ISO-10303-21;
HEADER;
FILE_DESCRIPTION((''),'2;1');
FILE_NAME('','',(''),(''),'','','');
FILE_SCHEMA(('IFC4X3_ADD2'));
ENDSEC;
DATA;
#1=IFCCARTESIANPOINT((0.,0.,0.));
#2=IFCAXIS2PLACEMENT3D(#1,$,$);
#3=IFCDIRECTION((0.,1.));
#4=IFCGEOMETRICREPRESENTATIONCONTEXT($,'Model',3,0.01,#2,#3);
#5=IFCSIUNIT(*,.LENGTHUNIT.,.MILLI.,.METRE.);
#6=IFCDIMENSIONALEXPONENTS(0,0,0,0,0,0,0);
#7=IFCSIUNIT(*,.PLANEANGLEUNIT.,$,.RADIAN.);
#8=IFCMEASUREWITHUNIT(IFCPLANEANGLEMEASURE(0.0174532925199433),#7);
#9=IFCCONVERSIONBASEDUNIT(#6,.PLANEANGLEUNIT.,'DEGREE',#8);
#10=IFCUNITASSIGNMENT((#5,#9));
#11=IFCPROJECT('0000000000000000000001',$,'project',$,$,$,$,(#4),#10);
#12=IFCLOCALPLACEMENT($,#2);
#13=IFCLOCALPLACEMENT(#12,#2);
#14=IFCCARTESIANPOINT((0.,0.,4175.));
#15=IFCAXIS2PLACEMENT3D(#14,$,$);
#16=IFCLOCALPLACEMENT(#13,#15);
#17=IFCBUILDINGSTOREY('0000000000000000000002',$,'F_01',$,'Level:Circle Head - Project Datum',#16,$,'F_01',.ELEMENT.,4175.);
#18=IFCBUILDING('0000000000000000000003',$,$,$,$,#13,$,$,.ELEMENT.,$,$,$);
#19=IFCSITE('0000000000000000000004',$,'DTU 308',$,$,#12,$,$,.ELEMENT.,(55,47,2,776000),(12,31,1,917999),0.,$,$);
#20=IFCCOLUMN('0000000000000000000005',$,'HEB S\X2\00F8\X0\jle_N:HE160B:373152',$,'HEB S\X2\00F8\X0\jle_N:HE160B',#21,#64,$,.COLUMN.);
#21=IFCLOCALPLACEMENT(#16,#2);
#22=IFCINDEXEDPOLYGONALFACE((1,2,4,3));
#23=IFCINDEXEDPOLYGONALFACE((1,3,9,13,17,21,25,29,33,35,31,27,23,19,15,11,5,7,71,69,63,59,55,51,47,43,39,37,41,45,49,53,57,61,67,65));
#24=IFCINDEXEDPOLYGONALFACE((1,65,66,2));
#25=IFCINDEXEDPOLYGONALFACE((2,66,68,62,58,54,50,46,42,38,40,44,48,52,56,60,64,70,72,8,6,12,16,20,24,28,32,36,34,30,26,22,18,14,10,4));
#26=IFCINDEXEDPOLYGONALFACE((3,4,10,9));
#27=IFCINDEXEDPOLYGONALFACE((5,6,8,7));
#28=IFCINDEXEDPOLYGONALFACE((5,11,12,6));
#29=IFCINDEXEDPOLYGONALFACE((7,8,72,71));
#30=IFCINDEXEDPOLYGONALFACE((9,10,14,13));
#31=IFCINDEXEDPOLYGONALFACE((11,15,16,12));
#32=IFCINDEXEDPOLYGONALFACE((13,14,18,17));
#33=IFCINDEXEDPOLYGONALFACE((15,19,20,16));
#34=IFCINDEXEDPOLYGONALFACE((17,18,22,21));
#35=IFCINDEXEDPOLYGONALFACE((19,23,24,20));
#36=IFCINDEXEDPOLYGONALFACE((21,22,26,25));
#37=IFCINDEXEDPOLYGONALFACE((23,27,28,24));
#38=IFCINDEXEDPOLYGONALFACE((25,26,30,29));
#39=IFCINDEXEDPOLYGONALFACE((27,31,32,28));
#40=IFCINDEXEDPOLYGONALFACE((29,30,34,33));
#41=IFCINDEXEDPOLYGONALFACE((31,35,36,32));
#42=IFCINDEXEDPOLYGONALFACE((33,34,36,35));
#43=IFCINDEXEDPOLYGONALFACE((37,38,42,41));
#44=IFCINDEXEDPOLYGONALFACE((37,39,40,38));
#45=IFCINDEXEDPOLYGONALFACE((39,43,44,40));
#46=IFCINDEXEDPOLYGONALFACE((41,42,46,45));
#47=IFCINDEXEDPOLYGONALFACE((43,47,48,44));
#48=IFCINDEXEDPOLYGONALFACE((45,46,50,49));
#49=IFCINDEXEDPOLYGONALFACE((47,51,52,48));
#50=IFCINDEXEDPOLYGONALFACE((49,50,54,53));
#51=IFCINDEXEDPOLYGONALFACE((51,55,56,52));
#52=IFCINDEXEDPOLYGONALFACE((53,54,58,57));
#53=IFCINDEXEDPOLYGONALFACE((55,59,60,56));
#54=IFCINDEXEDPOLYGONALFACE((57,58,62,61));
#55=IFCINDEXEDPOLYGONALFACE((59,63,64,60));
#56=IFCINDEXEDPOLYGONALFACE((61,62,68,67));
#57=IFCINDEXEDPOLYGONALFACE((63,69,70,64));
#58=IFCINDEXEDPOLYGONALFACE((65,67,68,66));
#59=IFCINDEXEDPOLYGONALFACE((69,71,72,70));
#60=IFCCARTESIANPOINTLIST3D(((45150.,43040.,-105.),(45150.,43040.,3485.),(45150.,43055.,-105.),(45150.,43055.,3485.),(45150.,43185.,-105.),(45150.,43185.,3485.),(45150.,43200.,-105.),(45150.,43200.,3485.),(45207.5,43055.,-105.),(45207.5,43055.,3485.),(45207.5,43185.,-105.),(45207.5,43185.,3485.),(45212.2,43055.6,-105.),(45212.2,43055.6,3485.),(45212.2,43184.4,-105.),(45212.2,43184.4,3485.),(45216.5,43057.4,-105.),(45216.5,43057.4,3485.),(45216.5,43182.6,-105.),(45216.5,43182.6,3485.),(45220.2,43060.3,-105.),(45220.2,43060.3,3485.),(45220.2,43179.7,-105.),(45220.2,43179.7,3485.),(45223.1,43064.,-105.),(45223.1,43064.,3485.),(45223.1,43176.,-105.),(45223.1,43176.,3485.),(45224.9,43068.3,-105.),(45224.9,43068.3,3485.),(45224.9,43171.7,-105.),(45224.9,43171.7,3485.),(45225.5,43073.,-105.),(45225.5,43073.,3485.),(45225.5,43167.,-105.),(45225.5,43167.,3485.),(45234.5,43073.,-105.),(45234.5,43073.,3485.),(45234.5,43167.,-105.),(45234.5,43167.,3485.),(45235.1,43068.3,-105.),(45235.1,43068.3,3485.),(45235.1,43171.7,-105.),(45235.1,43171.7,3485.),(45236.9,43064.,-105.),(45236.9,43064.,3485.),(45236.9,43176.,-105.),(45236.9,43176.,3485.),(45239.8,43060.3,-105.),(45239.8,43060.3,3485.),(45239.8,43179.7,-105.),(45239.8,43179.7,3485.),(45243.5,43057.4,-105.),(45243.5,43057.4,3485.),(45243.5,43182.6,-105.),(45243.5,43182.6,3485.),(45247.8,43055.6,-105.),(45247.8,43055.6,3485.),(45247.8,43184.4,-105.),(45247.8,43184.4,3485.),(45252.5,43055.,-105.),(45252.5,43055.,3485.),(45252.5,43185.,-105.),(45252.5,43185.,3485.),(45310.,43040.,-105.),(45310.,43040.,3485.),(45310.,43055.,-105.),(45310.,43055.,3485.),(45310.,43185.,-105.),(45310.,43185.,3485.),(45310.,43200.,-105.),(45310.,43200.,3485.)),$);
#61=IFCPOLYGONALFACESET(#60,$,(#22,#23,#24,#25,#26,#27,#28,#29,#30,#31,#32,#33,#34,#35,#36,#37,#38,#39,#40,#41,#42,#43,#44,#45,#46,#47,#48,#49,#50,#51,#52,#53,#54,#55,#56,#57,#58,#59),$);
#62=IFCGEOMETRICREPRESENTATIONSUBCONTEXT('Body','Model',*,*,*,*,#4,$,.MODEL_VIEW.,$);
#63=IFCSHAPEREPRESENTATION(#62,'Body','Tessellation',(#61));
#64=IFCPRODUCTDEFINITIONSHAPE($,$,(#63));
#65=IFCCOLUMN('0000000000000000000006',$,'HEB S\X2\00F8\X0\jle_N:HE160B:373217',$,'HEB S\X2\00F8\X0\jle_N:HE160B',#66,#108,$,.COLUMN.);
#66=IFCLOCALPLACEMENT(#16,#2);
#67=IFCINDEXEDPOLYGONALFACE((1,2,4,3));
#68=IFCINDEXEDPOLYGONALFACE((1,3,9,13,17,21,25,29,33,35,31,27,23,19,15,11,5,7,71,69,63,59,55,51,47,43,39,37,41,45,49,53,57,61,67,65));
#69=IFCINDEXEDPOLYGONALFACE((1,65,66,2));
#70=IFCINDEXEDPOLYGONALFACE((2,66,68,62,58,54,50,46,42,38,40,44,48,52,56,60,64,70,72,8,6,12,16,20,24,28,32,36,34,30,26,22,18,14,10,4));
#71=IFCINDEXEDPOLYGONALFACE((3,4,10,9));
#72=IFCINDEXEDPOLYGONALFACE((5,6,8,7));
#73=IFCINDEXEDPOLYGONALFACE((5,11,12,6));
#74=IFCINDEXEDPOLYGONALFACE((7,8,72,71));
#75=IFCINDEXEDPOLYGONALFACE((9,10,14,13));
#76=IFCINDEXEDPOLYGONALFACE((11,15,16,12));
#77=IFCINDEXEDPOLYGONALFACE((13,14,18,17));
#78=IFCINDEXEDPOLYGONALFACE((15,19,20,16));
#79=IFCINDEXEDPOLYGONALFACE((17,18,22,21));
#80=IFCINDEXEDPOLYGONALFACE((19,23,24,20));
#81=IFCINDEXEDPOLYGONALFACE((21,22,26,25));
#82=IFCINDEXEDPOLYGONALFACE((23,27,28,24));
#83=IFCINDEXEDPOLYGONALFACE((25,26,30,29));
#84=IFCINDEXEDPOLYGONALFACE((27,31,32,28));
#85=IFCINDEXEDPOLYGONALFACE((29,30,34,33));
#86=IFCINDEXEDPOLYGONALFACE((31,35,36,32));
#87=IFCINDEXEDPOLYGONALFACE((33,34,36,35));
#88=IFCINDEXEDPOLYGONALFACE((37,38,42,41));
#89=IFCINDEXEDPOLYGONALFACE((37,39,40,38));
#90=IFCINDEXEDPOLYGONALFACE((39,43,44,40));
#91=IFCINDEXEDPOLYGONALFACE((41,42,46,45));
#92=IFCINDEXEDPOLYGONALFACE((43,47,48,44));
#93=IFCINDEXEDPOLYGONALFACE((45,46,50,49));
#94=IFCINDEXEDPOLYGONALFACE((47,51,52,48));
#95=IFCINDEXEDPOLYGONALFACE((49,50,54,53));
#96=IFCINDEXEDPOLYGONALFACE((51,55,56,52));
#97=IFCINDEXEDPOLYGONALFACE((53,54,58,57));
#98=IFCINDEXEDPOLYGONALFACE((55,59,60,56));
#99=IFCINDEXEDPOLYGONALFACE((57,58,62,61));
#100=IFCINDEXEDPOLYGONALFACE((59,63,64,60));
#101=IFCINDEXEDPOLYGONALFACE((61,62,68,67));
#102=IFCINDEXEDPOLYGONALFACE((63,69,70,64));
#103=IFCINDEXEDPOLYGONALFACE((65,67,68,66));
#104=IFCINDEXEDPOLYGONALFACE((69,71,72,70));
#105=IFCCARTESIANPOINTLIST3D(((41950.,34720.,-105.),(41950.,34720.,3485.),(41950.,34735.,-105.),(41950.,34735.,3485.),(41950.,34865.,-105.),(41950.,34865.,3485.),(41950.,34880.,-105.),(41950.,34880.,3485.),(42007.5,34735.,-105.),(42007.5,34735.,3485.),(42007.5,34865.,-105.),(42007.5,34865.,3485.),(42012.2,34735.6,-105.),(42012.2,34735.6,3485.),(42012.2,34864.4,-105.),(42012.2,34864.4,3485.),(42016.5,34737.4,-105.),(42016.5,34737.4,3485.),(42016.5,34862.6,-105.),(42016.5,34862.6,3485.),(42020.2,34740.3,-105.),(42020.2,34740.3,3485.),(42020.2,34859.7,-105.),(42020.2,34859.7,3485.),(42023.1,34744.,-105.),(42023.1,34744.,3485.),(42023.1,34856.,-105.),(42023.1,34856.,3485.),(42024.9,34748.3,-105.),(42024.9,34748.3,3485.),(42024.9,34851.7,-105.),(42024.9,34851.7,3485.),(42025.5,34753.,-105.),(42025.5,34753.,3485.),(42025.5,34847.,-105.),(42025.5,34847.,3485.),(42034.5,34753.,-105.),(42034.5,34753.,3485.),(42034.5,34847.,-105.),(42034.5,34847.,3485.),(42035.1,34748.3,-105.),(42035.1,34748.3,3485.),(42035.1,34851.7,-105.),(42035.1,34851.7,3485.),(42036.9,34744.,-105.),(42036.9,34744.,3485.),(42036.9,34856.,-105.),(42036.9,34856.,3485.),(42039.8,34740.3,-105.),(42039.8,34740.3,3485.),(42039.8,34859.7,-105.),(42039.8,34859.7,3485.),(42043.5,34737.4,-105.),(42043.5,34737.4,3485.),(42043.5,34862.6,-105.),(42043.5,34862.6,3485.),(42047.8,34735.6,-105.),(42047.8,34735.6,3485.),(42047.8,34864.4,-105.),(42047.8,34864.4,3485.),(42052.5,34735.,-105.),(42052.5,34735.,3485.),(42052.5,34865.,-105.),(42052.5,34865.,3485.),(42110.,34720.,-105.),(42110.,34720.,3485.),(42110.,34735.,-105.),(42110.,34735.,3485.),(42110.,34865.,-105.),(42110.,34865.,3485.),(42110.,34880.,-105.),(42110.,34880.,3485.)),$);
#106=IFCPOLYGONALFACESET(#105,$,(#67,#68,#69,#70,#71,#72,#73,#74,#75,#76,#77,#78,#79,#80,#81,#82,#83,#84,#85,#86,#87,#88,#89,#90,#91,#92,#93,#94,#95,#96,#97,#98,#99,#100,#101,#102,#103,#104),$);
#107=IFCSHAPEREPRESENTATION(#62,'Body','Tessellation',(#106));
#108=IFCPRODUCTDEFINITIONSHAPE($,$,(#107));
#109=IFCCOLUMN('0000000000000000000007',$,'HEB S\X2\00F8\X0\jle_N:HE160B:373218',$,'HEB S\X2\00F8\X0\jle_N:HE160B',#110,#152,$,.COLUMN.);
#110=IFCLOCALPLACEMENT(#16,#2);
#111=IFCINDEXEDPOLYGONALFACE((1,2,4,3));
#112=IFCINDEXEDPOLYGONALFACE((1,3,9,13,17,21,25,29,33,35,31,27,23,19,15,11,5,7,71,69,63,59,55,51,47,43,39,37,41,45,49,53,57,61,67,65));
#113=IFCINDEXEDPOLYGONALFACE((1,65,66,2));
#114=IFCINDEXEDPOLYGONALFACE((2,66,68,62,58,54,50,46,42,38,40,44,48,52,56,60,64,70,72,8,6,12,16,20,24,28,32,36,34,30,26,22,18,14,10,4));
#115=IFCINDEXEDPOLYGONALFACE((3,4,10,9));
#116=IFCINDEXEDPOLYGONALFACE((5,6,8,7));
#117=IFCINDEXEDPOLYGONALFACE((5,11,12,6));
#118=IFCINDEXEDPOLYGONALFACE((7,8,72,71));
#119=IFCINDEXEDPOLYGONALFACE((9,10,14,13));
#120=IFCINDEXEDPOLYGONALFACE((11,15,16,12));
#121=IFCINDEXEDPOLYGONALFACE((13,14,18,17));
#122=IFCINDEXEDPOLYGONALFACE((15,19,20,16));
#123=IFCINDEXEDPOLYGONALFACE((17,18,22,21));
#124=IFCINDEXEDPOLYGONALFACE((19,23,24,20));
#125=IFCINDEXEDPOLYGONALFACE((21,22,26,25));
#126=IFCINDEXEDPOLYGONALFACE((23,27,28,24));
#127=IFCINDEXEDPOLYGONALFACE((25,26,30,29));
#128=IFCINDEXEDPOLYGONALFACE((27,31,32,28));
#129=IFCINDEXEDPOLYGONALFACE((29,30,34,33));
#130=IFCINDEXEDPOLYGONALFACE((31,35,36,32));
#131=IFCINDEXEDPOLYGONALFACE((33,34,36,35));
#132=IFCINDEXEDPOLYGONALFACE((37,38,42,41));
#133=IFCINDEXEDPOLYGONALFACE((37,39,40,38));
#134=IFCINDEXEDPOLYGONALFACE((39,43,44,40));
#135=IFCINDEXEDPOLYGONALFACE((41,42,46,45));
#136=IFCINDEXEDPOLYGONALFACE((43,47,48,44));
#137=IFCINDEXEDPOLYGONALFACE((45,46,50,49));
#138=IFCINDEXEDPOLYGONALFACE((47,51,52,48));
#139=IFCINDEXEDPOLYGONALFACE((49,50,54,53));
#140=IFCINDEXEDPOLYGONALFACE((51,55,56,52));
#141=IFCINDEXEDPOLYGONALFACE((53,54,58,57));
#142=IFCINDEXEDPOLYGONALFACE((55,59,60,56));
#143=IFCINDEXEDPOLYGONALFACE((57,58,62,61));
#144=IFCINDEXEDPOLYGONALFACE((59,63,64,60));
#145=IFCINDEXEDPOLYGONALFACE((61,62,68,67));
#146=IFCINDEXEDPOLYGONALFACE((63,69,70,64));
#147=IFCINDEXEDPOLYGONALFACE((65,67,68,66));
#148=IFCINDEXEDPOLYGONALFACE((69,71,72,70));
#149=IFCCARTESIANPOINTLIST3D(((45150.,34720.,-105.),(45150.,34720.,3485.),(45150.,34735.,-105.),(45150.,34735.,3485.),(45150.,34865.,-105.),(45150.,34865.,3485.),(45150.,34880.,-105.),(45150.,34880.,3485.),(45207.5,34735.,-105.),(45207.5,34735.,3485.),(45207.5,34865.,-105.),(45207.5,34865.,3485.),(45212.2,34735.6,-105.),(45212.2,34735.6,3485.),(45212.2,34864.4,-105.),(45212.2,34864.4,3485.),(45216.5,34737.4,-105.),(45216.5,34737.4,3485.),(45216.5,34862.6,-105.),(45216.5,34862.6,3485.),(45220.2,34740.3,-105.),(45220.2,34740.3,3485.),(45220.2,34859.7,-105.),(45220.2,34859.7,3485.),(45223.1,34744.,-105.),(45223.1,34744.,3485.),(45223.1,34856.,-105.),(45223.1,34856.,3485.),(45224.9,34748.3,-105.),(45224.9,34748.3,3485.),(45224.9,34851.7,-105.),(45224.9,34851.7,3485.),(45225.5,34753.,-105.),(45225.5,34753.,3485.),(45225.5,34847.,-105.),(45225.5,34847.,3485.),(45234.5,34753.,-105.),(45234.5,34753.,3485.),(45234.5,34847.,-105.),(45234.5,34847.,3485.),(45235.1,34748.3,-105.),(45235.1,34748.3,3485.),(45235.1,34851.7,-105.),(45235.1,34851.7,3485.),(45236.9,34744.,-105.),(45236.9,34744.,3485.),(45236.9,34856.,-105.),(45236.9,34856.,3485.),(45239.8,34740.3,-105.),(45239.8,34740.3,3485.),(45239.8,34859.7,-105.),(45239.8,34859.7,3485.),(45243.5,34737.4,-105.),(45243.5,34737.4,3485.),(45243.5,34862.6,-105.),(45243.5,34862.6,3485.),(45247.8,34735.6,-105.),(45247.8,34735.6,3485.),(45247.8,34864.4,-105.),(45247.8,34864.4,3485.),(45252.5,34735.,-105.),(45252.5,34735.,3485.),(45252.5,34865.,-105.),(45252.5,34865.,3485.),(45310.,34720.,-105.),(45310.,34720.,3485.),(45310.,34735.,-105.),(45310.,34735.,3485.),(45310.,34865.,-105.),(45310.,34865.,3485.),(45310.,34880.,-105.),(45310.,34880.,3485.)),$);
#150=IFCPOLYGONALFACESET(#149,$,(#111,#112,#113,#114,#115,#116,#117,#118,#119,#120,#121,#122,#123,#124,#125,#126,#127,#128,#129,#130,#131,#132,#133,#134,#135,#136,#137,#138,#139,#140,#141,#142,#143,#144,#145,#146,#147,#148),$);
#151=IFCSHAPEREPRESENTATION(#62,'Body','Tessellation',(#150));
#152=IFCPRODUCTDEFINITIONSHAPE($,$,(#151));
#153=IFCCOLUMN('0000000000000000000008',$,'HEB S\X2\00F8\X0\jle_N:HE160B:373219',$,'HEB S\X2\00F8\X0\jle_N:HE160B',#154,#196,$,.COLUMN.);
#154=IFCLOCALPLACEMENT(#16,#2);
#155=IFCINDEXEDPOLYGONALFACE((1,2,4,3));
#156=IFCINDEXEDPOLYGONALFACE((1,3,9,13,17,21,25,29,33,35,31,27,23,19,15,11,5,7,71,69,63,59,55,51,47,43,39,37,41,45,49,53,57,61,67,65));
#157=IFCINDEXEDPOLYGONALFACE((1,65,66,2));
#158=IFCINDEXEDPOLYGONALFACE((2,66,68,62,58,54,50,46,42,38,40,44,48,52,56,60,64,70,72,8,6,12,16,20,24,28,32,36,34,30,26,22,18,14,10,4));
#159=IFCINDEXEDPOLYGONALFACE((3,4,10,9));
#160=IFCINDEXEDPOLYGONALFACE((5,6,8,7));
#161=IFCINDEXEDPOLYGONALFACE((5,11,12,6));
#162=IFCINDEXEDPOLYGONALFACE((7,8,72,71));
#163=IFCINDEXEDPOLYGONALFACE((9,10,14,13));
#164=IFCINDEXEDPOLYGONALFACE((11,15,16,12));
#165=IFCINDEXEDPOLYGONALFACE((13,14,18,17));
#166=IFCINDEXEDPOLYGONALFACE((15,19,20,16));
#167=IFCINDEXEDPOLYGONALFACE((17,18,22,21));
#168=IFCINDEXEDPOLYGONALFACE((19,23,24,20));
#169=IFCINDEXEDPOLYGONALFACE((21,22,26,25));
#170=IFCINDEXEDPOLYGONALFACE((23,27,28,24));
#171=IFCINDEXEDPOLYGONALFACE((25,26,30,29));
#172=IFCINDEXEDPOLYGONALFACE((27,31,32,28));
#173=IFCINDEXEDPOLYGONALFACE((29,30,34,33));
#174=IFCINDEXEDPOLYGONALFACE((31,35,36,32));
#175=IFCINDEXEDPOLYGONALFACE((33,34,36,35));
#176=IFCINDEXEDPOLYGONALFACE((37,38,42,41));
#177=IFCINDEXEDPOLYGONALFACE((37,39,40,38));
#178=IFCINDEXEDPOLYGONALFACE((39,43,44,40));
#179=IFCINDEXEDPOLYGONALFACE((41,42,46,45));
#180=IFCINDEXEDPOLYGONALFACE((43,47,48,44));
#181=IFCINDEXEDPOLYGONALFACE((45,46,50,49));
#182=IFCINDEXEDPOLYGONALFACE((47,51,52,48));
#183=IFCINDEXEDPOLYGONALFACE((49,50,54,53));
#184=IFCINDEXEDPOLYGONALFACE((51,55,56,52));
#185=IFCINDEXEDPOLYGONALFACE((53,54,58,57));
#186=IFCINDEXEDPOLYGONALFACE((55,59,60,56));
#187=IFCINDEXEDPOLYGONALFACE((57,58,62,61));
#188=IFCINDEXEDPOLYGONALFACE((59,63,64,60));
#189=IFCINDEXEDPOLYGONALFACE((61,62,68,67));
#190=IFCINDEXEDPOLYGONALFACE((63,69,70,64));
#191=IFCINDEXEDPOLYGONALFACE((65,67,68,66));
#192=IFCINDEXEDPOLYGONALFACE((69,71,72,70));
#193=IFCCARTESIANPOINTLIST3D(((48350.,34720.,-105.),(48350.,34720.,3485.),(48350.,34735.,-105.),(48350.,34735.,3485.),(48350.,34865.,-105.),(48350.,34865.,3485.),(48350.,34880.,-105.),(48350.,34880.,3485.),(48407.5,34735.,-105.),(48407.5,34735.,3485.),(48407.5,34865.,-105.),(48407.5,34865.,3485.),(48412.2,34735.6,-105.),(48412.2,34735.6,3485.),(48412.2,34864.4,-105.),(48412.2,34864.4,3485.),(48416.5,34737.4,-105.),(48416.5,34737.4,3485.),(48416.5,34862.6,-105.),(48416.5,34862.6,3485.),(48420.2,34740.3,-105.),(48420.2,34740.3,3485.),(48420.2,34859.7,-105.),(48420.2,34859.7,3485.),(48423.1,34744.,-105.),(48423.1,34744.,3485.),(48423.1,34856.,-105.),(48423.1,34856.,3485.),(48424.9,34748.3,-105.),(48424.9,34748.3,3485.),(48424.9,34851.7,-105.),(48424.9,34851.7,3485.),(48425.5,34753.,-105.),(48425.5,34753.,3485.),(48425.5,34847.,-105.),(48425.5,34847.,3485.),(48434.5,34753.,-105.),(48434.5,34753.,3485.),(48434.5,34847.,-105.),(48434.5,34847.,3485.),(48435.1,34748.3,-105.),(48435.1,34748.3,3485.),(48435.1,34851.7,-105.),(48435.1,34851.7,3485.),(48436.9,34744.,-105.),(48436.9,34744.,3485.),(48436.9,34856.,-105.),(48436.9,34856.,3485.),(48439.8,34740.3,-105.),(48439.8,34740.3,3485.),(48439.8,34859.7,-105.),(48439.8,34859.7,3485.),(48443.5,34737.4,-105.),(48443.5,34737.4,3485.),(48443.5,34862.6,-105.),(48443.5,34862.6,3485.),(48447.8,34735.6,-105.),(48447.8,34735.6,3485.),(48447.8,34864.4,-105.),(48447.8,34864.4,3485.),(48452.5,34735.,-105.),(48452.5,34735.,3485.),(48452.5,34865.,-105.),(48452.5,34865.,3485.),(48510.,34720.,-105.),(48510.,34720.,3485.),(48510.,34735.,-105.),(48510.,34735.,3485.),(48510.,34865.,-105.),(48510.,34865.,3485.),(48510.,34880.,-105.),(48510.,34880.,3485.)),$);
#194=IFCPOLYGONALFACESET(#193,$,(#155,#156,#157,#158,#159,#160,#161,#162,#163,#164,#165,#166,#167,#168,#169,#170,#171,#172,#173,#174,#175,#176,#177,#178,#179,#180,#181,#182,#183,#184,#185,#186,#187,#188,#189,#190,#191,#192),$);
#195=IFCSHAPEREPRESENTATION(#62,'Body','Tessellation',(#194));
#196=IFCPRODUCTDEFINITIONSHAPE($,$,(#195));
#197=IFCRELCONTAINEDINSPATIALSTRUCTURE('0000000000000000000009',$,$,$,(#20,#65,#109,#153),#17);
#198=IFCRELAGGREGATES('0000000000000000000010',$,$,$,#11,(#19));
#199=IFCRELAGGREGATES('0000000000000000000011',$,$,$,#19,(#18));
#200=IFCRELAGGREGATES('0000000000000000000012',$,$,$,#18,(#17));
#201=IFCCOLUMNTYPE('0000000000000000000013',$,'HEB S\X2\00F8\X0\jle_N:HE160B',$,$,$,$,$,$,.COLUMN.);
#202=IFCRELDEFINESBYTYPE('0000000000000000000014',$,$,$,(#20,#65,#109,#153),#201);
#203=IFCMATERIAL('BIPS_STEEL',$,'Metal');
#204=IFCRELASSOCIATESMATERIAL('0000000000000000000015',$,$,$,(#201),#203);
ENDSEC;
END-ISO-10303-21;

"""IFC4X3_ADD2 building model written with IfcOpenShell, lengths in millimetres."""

from ifc_helpers import new_model, entity, si_unit, converted_unit, direction, frame, frame_2d, origin, place, context, subcontext, project, spatial, i_section, extrude, source, transform, mapped, material, material_profile, profile_set, type_object, element, save


model = new_model("IFC4X3_ADD2")

# Units and contexts
model_context = context("Model", 3, precision=0.01, world=origin(), true_north=direction((0.0, 1.0)))
body_context = subcontext(model_context, "Body", "Model", "MODEL_VIEW")
ifc_project = project(units=[si_unit("LENGTHUNIT", "METRE", prefix="MILLI"), converted_unit("PLANEANGLEUNIT", "DEGREE", entity("IfcPlaneAngleMeasure", 0.0174532925199433), si_unit("PLANEANGLEUNIT", "RADIAN"), dimensions=[0, 0, 0, 0, 0, 0, 0])], contexts=[model_context])

# Site, building, storey
site_placement = place(None, origin())
site = spatial("IfcSite", under=ifc_project, at=site_placement, Name="DTU 308", CompositionType="ELEMENT", RefLatitude=(55, 47, 2, 776000), RefLongitude=(12, 31, 1, 917999), RefElevation=0.0)
building_placement = place(site_placement, origin())
building = spatial("IfcBuilding", under=site, at=building_placement, CompositionType="ELEMENT")
storey_placement = place(building_placement, frame((0.0, 0.0, 4175.0)))
storey = spatial("IfcBuildingStorey", under=building, at=storey_placement, Name="F_01", ObjectType="Level:Circle Head - Project Datum", LongName="F_01", CompositionType="ELEMENT", Elevation=4175.0)

# Columns
ifc_material_1 = material(Name="BIPS_STEEL", Category="Metal")
ifc_material_profile_1 = material_profile(ifc_material_1, i_section(OverallWidth=160.0, OverallDepth=160.0, WebThickness=9.0, FlangeThickness=15.0, FilletRadius=18.0, at=frame_2d((0.0, 0.0), x_axis=(1.0, 0.0))), Name="HE160B")
ifc_profile_set_1 = profile_set([ifc_material_profile_1], Name="HE160B")
column_type_1 = type_object("IfcColumnType", Name="HEB Søjle_N:HE160B", PredefinedType="COLUMN", material=ifc_profile_set_1)
shared_shape_1 = source(origin(), body_context, "Body", "SweptSolid", [
    extrude(i_section(OverallWidth=160.0, OverallDepth=160.0, WebThickness=9.0, FlangeThickness=15.0, FilletRadius=18.0, at=frame_2d((0.0, 0.0), x_axis=(1.0, 0.0))), frame((0.0, 0.0, 4070.0), z_axis=(0.0, 0.0, 1.0), x_axis=(-1.0, 0.0, 0.0)), (0.0, 0.0, 1.0), 3590.0),
])
for number, where, name in (
    (1, (45230.0, 43120.0, -4175.0), "HEB Søjle_N:HE160B:373152"),
    (2, (42030.0, 34800.0, -4175.0), "HEB Søjle_N:HE160B:373217"),
    (3, (45230.0, 34800.0, -4175.0), "HEB Søjle_N:HE160B:373218"),
    (4, (48430.0, 34800.0, -4175.0), "HEB Søjle_N:HE160B:373219"),
):
    element("IfcColumn", number, at=place(storey_placement, frame(where)), inside=storey, type_object=column_type_1, Name=name, ObjectType="HEB Søjle_N:HE160B", PredefinedType="COLUMN", context=body_context, shape_type="MappedRepresentation", body=[
        mapped(shared_shape_1, transform((0.0, 0.0, 0.0), scale=1.0)),
    ])

save(model, "model.ifc")
